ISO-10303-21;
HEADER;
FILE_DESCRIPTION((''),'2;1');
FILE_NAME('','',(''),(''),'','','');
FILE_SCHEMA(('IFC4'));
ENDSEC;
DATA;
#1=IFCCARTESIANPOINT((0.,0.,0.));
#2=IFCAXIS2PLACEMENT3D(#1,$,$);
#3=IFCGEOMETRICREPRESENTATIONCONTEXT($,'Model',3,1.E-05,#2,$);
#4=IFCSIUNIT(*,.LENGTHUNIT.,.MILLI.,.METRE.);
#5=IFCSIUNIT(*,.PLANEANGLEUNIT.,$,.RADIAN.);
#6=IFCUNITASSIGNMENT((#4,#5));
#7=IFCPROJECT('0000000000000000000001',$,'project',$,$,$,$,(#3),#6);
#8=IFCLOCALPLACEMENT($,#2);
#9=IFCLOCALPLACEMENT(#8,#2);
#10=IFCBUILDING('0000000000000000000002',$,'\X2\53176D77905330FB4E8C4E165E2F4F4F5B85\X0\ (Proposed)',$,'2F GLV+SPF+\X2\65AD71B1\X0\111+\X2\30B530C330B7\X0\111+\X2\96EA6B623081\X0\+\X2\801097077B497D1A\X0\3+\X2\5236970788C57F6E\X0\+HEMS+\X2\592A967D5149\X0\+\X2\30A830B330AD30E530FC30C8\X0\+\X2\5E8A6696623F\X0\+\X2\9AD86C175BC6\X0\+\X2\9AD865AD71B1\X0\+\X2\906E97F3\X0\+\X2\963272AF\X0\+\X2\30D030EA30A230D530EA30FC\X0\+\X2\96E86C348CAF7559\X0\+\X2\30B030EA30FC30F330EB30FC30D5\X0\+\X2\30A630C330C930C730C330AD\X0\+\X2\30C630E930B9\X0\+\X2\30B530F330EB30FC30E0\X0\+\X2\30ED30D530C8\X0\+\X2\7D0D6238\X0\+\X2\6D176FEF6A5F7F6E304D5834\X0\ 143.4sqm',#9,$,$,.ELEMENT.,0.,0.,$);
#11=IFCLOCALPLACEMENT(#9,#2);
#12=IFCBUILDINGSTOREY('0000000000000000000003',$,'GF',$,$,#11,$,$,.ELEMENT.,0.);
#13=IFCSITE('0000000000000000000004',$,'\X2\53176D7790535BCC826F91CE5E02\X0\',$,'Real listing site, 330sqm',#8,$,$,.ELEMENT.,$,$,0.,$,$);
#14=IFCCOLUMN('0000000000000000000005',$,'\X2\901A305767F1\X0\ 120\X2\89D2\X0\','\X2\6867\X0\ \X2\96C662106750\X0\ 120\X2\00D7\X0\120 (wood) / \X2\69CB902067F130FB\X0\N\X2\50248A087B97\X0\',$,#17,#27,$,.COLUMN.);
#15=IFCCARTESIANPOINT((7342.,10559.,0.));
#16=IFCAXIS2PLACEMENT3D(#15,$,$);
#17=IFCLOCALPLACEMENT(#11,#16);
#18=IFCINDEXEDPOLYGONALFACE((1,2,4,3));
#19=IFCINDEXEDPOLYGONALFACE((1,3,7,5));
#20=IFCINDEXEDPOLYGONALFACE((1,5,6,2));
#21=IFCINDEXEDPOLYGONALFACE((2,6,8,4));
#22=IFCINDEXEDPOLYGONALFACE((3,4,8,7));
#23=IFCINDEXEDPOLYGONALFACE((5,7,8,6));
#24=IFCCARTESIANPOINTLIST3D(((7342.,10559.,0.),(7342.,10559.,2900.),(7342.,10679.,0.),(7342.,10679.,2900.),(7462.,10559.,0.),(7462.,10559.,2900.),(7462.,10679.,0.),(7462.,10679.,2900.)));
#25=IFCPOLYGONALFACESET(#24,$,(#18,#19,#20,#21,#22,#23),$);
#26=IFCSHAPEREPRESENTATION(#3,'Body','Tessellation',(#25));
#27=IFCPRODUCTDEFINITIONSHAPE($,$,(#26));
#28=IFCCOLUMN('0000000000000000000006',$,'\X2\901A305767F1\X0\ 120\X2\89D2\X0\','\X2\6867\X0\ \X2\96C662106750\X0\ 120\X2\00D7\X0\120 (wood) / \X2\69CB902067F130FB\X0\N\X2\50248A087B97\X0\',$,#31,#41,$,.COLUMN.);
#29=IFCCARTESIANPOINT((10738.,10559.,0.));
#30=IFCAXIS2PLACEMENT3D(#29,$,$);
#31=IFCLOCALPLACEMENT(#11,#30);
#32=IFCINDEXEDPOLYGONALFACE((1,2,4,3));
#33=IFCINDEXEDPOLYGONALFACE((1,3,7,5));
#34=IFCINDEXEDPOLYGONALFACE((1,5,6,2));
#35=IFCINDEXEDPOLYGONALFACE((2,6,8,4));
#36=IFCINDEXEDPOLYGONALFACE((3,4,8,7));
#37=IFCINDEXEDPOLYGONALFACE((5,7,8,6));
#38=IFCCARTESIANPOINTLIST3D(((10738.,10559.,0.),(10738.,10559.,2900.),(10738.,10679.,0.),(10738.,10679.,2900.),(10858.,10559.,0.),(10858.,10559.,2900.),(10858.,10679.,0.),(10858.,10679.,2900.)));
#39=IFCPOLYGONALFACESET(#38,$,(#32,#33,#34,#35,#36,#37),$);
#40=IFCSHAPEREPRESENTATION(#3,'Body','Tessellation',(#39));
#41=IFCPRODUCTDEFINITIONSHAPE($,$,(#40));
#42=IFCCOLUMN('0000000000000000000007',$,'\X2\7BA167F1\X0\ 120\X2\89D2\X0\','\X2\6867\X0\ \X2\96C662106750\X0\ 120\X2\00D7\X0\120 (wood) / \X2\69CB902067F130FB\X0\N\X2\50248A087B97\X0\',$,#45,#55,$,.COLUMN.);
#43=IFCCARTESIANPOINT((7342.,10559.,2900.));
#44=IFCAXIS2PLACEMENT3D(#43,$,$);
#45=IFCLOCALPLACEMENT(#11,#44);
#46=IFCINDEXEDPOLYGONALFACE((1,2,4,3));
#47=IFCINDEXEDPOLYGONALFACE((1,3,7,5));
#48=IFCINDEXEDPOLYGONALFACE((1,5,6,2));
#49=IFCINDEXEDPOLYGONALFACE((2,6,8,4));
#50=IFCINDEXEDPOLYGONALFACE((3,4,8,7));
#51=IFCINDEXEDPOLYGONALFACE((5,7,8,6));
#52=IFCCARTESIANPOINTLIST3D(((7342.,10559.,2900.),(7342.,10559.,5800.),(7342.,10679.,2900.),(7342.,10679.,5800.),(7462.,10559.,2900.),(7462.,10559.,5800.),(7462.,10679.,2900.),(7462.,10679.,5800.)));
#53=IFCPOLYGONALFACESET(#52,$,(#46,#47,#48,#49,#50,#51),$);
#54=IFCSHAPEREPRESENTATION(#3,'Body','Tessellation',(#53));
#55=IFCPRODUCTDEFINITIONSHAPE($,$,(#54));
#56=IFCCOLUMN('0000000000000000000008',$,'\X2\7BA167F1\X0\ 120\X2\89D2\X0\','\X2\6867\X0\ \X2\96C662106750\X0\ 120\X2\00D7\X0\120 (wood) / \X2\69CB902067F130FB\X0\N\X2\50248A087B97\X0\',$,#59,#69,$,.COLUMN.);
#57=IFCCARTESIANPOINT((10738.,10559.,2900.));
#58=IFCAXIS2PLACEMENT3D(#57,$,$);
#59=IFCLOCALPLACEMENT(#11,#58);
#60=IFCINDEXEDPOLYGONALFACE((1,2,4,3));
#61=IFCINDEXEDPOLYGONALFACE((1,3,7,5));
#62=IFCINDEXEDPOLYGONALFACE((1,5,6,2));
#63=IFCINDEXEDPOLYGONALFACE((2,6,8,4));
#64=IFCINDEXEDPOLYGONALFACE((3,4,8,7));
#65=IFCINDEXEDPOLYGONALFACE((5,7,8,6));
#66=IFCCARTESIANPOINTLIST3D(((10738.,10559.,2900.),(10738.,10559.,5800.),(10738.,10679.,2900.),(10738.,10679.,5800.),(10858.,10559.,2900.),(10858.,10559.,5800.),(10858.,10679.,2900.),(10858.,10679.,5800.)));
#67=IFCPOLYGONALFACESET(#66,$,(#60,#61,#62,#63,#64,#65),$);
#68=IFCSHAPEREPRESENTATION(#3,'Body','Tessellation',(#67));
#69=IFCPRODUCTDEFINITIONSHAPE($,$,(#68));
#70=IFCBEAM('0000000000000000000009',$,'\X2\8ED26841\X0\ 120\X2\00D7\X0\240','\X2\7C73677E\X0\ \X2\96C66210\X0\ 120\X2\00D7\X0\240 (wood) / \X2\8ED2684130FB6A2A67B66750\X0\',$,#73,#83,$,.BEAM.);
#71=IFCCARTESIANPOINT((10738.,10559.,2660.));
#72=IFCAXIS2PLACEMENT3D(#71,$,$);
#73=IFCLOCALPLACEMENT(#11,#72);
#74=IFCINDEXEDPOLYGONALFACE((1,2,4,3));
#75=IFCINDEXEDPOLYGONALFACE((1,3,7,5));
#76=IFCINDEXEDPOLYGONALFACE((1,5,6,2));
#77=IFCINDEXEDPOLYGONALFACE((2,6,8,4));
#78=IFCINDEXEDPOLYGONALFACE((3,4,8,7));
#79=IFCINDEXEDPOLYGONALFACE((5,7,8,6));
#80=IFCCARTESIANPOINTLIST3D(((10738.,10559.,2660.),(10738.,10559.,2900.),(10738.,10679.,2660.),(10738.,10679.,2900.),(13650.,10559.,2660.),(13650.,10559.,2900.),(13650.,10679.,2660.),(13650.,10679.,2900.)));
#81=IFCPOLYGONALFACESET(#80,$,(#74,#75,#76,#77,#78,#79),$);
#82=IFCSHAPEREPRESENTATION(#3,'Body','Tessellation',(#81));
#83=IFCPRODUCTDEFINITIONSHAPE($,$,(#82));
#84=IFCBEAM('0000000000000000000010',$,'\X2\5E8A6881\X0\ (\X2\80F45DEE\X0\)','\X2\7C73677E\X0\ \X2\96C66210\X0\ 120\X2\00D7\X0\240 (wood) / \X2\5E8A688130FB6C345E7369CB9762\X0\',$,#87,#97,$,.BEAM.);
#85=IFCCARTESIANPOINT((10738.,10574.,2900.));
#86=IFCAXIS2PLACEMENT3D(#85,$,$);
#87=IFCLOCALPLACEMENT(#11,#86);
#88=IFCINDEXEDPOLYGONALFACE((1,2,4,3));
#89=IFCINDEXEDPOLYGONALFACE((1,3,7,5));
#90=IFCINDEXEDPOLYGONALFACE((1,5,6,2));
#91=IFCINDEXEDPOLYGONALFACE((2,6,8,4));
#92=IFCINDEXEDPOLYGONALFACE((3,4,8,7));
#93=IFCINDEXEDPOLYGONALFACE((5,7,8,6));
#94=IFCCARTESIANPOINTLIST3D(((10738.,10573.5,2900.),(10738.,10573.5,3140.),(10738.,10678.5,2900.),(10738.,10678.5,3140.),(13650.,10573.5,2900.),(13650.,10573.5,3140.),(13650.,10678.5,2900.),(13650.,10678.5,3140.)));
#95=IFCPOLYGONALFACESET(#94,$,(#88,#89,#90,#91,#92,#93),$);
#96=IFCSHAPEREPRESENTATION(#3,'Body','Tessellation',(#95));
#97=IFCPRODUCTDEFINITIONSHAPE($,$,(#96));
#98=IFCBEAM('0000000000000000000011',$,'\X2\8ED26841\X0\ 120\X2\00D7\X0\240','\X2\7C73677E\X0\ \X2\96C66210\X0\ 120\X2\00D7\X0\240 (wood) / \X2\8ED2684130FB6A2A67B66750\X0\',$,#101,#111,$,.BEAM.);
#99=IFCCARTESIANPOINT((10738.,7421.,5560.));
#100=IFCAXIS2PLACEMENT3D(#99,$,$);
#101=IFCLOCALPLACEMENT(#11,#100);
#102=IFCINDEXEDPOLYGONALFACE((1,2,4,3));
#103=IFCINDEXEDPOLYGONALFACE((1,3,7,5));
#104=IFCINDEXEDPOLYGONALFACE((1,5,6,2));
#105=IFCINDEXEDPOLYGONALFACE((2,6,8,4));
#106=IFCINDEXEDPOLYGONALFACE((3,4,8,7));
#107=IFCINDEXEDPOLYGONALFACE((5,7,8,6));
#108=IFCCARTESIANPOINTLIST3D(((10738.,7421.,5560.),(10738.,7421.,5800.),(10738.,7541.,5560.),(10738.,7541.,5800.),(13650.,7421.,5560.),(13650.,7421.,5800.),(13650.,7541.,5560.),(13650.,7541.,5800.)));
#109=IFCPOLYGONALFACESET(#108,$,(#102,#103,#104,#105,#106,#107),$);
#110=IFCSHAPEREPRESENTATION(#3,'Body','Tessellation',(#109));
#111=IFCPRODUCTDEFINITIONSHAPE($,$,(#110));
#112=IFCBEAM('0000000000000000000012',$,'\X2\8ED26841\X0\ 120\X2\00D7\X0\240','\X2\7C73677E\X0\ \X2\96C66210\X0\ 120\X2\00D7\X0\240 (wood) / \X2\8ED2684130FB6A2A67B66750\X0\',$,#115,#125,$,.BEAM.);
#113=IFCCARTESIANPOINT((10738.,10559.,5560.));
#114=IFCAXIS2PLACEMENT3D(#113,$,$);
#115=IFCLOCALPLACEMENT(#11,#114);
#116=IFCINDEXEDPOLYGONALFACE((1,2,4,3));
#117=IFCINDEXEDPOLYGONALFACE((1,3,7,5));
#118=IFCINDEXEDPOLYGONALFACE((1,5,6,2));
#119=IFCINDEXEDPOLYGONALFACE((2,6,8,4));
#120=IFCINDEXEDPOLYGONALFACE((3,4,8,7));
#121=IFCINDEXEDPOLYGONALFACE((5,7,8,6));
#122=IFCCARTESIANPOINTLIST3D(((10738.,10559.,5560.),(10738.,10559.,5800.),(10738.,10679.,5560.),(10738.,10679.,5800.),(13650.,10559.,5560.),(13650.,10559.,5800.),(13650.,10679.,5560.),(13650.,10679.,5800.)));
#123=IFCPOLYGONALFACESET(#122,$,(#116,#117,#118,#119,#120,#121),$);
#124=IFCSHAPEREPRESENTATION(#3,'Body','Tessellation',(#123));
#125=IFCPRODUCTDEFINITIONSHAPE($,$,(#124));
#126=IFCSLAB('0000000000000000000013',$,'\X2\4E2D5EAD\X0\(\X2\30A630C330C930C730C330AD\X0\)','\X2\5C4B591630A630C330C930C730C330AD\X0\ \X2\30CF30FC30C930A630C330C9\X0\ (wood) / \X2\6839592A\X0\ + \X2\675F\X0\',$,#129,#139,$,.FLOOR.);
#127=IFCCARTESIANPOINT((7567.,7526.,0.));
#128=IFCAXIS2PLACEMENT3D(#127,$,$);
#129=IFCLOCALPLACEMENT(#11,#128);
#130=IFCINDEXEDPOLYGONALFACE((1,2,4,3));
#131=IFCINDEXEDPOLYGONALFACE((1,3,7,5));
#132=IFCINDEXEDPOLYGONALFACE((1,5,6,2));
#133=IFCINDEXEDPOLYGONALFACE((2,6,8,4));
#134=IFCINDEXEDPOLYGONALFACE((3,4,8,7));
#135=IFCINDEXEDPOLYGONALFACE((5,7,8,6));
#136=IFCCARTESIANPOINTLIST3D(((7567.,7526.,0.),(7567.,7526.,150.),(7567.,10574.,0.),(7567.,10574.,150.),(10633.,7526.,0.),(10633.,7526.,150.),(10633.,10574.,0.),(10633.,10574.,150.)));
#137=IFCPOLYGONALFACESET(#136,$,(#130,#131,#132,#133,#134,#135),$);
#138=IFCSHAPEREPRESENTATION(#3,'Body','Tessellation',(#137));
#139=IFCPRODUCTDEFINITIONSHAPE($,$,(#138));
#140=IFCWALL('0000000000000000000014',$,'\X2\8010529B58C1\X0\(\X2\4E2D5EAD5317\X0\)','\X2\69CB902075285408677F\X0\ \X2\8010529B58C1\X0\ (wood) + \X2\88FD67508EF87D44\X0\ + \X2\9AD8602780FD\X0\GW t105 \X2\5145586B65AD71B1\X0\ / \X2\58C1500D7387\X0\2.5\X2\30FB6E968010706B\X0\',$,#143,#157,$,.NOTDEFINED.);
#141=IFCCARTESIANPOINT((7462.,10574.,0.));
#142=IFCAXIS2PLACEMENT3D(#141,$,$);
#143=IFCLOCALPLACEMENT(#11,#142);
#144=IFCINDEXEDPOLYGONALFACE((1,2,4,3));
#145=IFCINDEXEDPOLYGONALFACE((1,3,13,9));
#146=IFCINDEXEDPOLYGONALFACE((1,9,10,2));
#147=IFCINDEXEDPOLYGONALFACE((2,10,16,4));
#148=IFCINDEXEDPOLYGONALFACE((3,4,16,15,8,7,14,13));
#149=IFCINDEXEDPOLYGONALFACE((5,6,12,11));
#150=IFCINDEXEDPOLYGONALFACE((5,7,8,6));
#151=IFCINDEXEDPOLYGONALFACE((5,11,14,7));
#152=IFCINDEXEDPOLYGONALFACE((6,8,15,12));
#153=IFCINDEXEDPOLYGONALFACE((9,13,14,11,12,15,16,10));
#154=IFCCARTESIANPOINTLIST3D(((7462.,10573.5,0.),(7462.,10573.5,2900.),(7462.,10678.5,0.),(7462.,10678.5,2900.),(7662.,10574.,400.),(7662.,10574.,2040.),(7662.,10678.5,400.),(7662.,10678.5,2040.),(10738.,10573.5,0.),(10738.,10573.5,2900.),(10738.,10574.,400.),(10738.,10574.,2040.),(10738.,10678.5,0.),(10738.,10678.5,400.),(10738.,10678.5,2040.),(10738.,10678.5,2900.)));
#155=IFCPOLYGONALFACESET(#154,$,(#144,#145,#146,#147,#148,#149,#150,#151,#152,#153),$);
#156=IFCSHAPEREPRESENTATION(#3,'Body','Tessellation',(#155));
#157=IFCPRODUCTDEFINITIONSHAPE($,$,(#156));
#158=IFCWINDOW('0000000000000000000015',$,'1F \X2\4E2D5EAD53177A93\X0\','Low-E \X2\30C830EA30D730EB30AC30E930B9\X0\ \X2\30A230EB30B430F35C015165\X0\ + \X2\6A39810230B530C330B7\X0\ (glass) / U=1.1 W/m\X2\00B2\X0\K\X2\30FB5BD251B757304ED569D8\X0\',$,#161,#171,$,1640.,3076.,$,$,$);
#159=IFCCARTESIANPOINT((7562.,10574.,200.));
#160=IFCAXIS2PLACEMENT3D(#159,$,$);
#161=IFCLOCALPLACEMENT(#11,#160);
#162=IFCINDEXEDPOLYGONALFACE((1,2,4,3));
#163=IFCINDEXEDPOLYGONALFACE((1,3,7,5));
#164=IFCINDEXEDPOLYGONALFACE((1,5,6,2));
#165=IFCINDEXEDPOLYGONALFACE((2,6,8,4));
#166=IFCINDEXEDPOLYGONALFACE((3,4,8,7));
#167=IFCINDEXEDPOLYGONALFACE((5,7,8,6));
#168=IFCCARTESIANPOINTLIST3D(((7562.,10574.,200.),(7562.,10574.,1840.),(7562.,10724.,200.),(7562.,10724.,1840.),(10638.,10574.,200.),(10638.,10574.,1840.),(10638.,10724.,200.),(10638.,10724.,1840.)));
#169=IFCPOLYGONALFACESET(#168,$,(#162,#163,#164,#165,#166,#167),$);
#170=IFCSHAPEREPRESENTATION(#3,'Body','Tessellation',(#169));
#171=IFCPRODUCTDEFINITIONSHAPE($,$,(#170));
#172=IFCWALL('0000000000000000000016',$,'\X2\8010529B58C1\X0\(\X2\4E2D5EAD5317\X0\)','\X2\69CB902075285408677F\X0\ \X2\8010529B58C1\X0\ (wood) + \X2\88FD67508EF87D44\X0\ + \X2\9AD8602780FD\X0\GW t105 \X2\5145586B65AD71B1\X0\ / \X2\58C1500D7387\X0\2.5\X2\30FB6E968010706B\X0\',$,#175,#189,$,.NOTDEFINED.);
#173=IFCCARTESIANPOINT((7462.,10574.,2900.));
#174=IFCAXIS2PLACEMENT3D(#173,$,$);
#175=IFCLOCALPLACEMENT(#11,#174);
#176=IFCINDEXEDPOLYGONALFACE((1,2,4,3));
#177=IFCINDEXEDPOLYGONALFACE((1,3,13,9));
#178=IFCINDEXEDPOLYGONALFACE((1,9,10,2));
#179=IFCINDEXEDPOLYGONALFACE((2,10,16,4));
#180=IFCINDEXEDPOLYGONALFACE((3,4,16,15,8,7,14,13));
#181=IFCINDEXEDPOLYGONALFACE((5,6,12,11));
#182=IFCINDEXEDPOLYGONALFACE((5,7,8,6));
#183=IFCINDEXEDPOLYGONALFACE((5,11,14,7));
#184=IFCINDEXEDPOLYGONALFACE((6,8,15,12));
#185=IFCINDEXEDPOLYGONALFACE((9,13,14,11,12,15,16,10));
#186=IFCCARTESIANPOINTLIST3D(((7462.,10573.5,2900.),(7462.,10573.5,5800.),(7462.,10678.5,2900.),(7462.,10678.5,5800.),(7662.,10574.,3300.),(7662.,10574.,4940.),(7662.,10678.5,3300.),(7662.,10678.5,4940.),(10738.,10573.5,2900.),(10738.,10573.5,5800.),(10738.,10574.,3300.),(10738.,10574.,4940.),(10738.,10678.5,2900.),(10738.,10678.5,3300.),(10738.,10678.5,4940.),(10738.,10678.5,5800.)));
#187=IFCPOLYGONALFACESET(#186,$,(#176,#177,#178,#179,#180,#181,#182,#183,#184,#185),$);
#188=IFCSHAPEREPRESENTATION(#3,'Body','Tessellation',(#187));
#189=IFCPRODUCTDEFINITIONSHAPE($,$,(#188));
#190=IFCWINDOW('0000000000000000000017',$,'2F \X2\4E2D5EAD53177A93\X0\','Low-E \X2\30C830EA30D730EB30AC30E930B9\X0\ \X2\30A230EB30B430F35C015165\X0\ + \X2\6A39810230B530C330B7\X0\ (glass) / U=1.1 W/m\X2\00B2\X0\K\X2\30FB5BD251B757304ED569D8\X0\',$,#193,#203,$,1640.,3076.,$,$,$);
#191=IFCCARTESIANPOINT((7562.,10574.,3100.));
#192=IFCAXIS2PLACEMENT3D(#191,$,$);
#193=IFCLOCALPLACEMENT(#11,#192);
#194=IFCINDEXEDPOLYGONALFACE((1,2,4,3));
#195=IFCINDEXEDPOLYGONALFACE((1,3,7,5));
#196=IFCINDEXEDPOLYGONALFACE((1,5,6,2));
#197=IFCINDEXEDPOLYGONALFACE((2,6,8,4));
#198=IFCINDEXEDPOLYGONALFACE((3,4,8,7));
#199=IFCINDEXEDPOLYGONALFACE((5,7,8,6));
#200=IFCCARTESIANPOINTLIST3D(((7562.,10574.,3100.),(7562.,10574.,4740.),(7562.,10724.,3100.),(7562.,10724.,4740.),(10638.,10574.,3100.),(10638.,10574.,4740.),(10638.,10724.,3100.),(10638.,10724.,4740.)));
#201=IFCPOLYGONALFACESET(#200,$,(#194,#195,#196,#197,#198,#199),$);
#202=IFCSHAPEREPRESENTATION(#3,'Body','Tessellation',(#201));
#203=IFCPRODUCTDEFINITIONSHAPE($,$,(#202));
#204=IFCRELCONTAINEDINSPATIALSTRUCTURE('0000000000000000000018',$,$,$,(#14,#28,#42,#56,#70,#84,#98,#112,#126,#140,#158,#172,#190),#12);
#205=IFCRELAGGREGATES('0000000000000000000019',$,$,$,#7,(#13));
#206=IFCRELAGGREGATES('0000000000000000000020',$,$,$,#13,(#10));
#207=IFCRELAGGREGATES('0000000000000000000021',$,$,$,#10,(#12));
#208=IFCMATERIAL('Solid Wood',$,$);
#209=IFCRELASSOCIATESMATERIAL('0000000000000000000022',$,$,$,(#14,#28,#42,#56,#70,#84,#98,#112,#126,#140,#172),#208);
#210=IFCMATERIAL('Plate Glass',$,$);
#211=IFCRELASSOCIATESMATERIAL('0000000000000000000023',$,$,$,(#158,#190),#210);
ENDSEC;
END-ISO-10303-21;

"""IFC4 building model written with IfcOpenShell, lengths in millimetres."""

from ifc_helpers import new_model, si_unit, frame, frame_2d, origin, place, context, project, spatial, rectangle, extrude, material, element, fill, save


model = new_model("IFC4")

# Units and contexts
model_context = context("Model", 3, precision=1e-05, world=origin())
ifc_project = project(units=[si_unit("LENGTHUNIT", "METRE", prefix="MILLI"), si_unit("PLANEANGLEUNIT", "RADIAN")], contexts=[model_context])

# Site, building, storey
site_placement = place(None, origin())
site = spatial("IfcSite", under=ifc_project, at=site_placement, Name="北海道富良野市", ObjectType="Real listing site, 330sqm", CompositionType="ELEMENT", RefElevation=0.0)
building_placement = place(site_placement, origin())
building = spatial("IfcBuilding", under=site, at=building_placement, Name="北海道・二世帯住宅 (Proposed)", ObjectType="2F GLV+SPF+断熱111+サッシ111+雪止め+耐震等級3+制震装置+HEMS+太陽光+エコキュート+床暖房+高気密+高断熱+遮音+防犯+バリアフリー+雨水貯留+グリーンルーフ+ウッドデッキ+テラス+サンルーム+ロフト+納戸+洗濯機置き場 143.4sqm", CompositionType="ELEMENT", ElevationOfRefHeight=0.0, ElevationOfTerrain=0.0)
storey_placement = place(building_placement, origin())
storey = spatial("IfcBuildingStorey", under=building, at=storey_placement, Name="GF", CompositionType="ELEMENT", Elevation=0.0)

# Columns
ifc_material_1 = material(Name="Solid Wood")
column_1_placement = place(storey_placement, frame((7342.0, 10559.0, 0.0)))
element("IfcColumn", 1, at=column_1_placement, inside=storey, material=ifc_material_1, Name="通し柱 120角", Description="桧 集成材 120×120 (wood) / 構造柱・N値計算", PredefinedType="COLUMN", context=model_context, shape_type="SweptSolid", body=[
    extrude(rectangle(XDim=120.0, YDim=120.0, at=frame_2d((60.0, 60.0))), frame((7342.0, 10559.0, 0.0)), (0.0, 0.0, 1.0), 2900.0),
])
column_2_placement = place(storey_placement, frame((10738.0, 10559.0, 0.0)))
element("IfcColumn", 2, at=column_2_placement, inside=storey, material=ifc_material_1, Name="通し柱 120角", Description="桧 集成材 120×120 (wood) / 構造柱・N値計算", PredefinedType="COLUMN", context=model_context, shape_type="SweptSolid", body=[
    extrude(rectangle(XDim=120.0, YDim=120.0, at=frame_2d((60.0, 60.0))), frame((10738.0, 10559.0, 0.0)), (0.0, 0.0, 1.0), 2900.0),
])
column_3_placement = place(storey_placement, frame((7342.0, 10559.0, 2900.0)))
element("IfcColumn", 3, at=column_3_placement, inside=storey, material=ifc_material_1, Name="管柱 120角", Description="桧 集成材 120×120 (wood) / 構造柱・N値計算", PredefinedType="COLUMN", context=model_context, shape_type="SweptSolid", body=[
    extrude(rectangle(XDim=120.0, YDim=120.0, at=frame_2d((60.0, 60.0))), frame((7342.0, 10559.0, 2900.0)), (0.0, 0.0, 1.0), 2900.0),
])
column_4_placement = place(storey_placement, frame((10738.0, 10559.0, 2900.0)))
element("IfcColumn", 4, at=column_4_placement, inside=storey, material=ifc_material_1, Name="管柱 120角", Description="桧 集成材 120×120 (wood) / 構造柱・N値計算", PredefinedType="COLUMN", context=model_context, shape_type="SweptSolid", body=[
    extrude(rectangle(XDim=120.0, YDim=120.0, at=frame_2d((60.0, 60.0))), frame((10738.0, 10559.0, 2900.0)), (0.0, 0.0, 1.0), 2900.0),
])

# Beams
beam_1_placement = place(storey_placement, frame((10738.0, 10559.0, 2660.0)))
element("IfcBeam", 5, at=beam_1_placement, inside=storey, material=ifc_material_1, Name="軒桁 120×240", Description="米松 集成 120×240 (wood) / 軒桁・横架材", PredefinedType="BEAM", context=model_context, shape_type="SweptSolid", body=[
    extrude(rectangle(XDim=2912.0, YDim=120.0, at=frame_2d((1456.0, 60.0))), frame((10738.0, 10559.0, 2660.0)), (0.0, 0.0, 1.0), 240.0),
])
beam_2_placement = place(storey_placement, frame((10738.0, 10574.0, 2900.0)))
element("IfcBeam", 6, at=beam_2_placement, inside=storey, material=ifc_material_1, Name="床梁 (胴差)", Description="米松 集成 120×240 (wood) / 床梁・水平構面", PredefinedType="BEAM", context=model_context, shape_type="SweptSolid", body=[
    extrude(rectangle(XDim=2912.0, YDim=105.0, at=frame_2d((1456.0, 52.0))), frame((10738.0, 10574.0, 2900.0)), (0.0, 0.0, 1.0), 240.0),
])
beam_3_placement = place(storey_placement, frame((10738.0, 7421.0, 5560.0)))
element("IfcBeam", 7, at=beam_3_placement, inside=storey, material=ifc_material_1, Name="軒桁 120×240", Description="米松 集成 120×240 (wood) / 軒桁・横架材", PredefinedType="BEAM", context=model_context, shape_type="SweptSolid", body=[
    extrude(rectangle(XDim=2912.0, YDim=120.0, at=frame_2d((1456.0, 60.0))), frame((10738.0, 7421.0, 5560.0)), (0.0, 0.0, 1.0), 240.0),
])
beam_4_placement = place(storey_placement, frame((10738.0, 10559.0, 5560.0)))
element("IfcBeam", 8, at=beam_4_placement, inside=storey, material=ifc_material_1, Name="軒桁 120×240", Description="米松 集成 120×240 (wood) / 軒桁・横架材", PredefinedType="BEAM", context=model_context, shape_type="SweptSolid", body=[
    extrude(rectangle(XDim=2912.0, YDim=120.0, at=frame_2d((1456.0, 60.0))), frame((10738.0, 10559.0, 5560.0)), (0.0, 0.0, 1.0), 240.0),
])

# Slab
slab_placement = place(storey_placement, frame((7567.0, 7526.0, 0.0)))
element("IfcSlab", 9, at=slab_placement, inside=storey, material=ifc_material_1, Name="中庭(ウッドデッキ)", Description="屋外ウッドデッキ ハードウッド (wood) / 根太 + 束", PredefinedType="FLOOR", context=model_context, shape_type="SweptSolid", body=[
    extrude(rectangle(XDim=3066.0, YDim=3048.0, at=frame_2d((1533.0, 1524.0))), frame((7567.0, 7526.0, 0.0)), (0.0, 0.0, 1.0), 150.0),
])

# Wall, opening, window
wall_1_placement = place(storey_placement, frame((7462.0, 10574.0, 0.0)))
wall_1 = element("IfcWall", 10, at=wall_1_placement, inside=storey, material=ifc_material_1, Name="耐力壁(中庭北)", Description="構造用合板 耐力壁 (wood) + 製材軸組 + 高性能GW t105 充填断熱 / 壁倍率2.5・準耐火", PredefinedType="NOTDEFINED", context=model_context, shape_type="SweptSolid", body=[
    extrude(rectangle(XDim=3276.0, YDim=105.0, at=frame_2d((1638.0, 52.0))), frame((7462.0, 10574.0, 0.0)), (0.0, 0.0, 1.0), 2900.0),
])
opening_1_placement = place(storey_placement, frame((7562.0, 10574.0, 200.0)))
opening_1 = element("IfcOpeningElement", 11, at=opening_1_placement, cuts=wall_1, PredefinedType="NOTDEFINED", context=model_context, shape_type="SweptSolid", body=[
    extrude(rectangle(XDim=3076.0, YDim=150.0, at=frame_2d((1538.0, 75.0))), frame((7562.0, 10574.0, 200.0)), (0.0, 0.0, 1.0), 1640.0),
])
ifc_material_2 = material(Name="Plate Glass")
window_1_placement = place(storey_placement, frame((7562.0, 10574.0, 200.0)))
window_1 = element("IfcWindow", 12, at=window_1_placement, inside=storey, material=ifc_material_2, Name="1F 中庭北窓", Description="Low-E トリプルガラス アルゴン封入 + 樹脂サッシ (glass) / U=1.1 W/m²K・寒冷地仕様", OverallHeight=1640.0, OverallWidth=3076.0, context=model_context, shape_type="SweptSolid", body=[
    extrude(rectangle(XDim=3076.0, YDim=150.0, at=frame_2d((1538.0, 75.0))), frame((7562.0, 10574.0, 200.0)), (0.0, 0.0, 1.0), 1640.0),
])
fill(opening_1, window_1)

# Wall, opening, window
wall_2_placement = place(storey_placement, frame((7462.0, 10574.0, 2900.0)))
wall_2 = element("IfcWall", 13, at=wall_2_placement, inside=storey, material=ifc_material_1, Name="耐力壁(中庭北)", Description="構造用合板 耐力壁 (wood) + 製材軸組 + 高性能GW t105 充填断熱 / 壁倍率2.5・準耐火", PredefinedType="NOTDEFINED", context=model_context, shape_type="SweptSolid", body=[
    extrude(rectangle(XDim=3276.0, YDim=105.0, at=frame_2d((1638.0, 52.0))), frame((7462.0, 10574.0, 2900.0)), (0.0, 0.0, 1.0), 2900.0),
])
opening_2_placement = place(storey_placement, frame((7562.0, 10574.0, 3100.0)))
opening_2 = element("IfcOpeningElement", 14, at=opening_2_placement, cuts=wall_2, PredefinedType="NOTDEFINED", context=model_context, shape_type="SweptSolid", body=[
    extrude(rectangle(XDim=3076.0, YDim=150.0, at=frame_2d((1538.0, 75.0))), frame((7562.0, 10574.0, 3100.0)), (0.0, 0.0, 1.0), 1640.0),
])
window_2_placement = place(storey_placement, frame((7562.0, 10574.0, 3100.0)))
window_2 = element("IfcWindow", 15, at=window_2_placement, inside=storey, material=ifc_material_2, Name="2F 中庭北窓", Description="Low-E トリプルガラス アルゴン封入 + 樹脂サッシ (glass) / U=1.1 W/m²K・寒冷地仕様", OverallHeight=1640.0, OverallWidth=3076.0, context=model_context, shape_type="SweptSolid", body=[
    extrude(rectangle(XDim=3076.0, YDim=150.0, at=frame_2d((1538.0, 75.0))), frame((7562.0, 10574.0, 3100.0)), (0.0, 0.0, 1.0), 1640.0),
])
fill(opening_2, window_2)

save(model, "model.ifc")
